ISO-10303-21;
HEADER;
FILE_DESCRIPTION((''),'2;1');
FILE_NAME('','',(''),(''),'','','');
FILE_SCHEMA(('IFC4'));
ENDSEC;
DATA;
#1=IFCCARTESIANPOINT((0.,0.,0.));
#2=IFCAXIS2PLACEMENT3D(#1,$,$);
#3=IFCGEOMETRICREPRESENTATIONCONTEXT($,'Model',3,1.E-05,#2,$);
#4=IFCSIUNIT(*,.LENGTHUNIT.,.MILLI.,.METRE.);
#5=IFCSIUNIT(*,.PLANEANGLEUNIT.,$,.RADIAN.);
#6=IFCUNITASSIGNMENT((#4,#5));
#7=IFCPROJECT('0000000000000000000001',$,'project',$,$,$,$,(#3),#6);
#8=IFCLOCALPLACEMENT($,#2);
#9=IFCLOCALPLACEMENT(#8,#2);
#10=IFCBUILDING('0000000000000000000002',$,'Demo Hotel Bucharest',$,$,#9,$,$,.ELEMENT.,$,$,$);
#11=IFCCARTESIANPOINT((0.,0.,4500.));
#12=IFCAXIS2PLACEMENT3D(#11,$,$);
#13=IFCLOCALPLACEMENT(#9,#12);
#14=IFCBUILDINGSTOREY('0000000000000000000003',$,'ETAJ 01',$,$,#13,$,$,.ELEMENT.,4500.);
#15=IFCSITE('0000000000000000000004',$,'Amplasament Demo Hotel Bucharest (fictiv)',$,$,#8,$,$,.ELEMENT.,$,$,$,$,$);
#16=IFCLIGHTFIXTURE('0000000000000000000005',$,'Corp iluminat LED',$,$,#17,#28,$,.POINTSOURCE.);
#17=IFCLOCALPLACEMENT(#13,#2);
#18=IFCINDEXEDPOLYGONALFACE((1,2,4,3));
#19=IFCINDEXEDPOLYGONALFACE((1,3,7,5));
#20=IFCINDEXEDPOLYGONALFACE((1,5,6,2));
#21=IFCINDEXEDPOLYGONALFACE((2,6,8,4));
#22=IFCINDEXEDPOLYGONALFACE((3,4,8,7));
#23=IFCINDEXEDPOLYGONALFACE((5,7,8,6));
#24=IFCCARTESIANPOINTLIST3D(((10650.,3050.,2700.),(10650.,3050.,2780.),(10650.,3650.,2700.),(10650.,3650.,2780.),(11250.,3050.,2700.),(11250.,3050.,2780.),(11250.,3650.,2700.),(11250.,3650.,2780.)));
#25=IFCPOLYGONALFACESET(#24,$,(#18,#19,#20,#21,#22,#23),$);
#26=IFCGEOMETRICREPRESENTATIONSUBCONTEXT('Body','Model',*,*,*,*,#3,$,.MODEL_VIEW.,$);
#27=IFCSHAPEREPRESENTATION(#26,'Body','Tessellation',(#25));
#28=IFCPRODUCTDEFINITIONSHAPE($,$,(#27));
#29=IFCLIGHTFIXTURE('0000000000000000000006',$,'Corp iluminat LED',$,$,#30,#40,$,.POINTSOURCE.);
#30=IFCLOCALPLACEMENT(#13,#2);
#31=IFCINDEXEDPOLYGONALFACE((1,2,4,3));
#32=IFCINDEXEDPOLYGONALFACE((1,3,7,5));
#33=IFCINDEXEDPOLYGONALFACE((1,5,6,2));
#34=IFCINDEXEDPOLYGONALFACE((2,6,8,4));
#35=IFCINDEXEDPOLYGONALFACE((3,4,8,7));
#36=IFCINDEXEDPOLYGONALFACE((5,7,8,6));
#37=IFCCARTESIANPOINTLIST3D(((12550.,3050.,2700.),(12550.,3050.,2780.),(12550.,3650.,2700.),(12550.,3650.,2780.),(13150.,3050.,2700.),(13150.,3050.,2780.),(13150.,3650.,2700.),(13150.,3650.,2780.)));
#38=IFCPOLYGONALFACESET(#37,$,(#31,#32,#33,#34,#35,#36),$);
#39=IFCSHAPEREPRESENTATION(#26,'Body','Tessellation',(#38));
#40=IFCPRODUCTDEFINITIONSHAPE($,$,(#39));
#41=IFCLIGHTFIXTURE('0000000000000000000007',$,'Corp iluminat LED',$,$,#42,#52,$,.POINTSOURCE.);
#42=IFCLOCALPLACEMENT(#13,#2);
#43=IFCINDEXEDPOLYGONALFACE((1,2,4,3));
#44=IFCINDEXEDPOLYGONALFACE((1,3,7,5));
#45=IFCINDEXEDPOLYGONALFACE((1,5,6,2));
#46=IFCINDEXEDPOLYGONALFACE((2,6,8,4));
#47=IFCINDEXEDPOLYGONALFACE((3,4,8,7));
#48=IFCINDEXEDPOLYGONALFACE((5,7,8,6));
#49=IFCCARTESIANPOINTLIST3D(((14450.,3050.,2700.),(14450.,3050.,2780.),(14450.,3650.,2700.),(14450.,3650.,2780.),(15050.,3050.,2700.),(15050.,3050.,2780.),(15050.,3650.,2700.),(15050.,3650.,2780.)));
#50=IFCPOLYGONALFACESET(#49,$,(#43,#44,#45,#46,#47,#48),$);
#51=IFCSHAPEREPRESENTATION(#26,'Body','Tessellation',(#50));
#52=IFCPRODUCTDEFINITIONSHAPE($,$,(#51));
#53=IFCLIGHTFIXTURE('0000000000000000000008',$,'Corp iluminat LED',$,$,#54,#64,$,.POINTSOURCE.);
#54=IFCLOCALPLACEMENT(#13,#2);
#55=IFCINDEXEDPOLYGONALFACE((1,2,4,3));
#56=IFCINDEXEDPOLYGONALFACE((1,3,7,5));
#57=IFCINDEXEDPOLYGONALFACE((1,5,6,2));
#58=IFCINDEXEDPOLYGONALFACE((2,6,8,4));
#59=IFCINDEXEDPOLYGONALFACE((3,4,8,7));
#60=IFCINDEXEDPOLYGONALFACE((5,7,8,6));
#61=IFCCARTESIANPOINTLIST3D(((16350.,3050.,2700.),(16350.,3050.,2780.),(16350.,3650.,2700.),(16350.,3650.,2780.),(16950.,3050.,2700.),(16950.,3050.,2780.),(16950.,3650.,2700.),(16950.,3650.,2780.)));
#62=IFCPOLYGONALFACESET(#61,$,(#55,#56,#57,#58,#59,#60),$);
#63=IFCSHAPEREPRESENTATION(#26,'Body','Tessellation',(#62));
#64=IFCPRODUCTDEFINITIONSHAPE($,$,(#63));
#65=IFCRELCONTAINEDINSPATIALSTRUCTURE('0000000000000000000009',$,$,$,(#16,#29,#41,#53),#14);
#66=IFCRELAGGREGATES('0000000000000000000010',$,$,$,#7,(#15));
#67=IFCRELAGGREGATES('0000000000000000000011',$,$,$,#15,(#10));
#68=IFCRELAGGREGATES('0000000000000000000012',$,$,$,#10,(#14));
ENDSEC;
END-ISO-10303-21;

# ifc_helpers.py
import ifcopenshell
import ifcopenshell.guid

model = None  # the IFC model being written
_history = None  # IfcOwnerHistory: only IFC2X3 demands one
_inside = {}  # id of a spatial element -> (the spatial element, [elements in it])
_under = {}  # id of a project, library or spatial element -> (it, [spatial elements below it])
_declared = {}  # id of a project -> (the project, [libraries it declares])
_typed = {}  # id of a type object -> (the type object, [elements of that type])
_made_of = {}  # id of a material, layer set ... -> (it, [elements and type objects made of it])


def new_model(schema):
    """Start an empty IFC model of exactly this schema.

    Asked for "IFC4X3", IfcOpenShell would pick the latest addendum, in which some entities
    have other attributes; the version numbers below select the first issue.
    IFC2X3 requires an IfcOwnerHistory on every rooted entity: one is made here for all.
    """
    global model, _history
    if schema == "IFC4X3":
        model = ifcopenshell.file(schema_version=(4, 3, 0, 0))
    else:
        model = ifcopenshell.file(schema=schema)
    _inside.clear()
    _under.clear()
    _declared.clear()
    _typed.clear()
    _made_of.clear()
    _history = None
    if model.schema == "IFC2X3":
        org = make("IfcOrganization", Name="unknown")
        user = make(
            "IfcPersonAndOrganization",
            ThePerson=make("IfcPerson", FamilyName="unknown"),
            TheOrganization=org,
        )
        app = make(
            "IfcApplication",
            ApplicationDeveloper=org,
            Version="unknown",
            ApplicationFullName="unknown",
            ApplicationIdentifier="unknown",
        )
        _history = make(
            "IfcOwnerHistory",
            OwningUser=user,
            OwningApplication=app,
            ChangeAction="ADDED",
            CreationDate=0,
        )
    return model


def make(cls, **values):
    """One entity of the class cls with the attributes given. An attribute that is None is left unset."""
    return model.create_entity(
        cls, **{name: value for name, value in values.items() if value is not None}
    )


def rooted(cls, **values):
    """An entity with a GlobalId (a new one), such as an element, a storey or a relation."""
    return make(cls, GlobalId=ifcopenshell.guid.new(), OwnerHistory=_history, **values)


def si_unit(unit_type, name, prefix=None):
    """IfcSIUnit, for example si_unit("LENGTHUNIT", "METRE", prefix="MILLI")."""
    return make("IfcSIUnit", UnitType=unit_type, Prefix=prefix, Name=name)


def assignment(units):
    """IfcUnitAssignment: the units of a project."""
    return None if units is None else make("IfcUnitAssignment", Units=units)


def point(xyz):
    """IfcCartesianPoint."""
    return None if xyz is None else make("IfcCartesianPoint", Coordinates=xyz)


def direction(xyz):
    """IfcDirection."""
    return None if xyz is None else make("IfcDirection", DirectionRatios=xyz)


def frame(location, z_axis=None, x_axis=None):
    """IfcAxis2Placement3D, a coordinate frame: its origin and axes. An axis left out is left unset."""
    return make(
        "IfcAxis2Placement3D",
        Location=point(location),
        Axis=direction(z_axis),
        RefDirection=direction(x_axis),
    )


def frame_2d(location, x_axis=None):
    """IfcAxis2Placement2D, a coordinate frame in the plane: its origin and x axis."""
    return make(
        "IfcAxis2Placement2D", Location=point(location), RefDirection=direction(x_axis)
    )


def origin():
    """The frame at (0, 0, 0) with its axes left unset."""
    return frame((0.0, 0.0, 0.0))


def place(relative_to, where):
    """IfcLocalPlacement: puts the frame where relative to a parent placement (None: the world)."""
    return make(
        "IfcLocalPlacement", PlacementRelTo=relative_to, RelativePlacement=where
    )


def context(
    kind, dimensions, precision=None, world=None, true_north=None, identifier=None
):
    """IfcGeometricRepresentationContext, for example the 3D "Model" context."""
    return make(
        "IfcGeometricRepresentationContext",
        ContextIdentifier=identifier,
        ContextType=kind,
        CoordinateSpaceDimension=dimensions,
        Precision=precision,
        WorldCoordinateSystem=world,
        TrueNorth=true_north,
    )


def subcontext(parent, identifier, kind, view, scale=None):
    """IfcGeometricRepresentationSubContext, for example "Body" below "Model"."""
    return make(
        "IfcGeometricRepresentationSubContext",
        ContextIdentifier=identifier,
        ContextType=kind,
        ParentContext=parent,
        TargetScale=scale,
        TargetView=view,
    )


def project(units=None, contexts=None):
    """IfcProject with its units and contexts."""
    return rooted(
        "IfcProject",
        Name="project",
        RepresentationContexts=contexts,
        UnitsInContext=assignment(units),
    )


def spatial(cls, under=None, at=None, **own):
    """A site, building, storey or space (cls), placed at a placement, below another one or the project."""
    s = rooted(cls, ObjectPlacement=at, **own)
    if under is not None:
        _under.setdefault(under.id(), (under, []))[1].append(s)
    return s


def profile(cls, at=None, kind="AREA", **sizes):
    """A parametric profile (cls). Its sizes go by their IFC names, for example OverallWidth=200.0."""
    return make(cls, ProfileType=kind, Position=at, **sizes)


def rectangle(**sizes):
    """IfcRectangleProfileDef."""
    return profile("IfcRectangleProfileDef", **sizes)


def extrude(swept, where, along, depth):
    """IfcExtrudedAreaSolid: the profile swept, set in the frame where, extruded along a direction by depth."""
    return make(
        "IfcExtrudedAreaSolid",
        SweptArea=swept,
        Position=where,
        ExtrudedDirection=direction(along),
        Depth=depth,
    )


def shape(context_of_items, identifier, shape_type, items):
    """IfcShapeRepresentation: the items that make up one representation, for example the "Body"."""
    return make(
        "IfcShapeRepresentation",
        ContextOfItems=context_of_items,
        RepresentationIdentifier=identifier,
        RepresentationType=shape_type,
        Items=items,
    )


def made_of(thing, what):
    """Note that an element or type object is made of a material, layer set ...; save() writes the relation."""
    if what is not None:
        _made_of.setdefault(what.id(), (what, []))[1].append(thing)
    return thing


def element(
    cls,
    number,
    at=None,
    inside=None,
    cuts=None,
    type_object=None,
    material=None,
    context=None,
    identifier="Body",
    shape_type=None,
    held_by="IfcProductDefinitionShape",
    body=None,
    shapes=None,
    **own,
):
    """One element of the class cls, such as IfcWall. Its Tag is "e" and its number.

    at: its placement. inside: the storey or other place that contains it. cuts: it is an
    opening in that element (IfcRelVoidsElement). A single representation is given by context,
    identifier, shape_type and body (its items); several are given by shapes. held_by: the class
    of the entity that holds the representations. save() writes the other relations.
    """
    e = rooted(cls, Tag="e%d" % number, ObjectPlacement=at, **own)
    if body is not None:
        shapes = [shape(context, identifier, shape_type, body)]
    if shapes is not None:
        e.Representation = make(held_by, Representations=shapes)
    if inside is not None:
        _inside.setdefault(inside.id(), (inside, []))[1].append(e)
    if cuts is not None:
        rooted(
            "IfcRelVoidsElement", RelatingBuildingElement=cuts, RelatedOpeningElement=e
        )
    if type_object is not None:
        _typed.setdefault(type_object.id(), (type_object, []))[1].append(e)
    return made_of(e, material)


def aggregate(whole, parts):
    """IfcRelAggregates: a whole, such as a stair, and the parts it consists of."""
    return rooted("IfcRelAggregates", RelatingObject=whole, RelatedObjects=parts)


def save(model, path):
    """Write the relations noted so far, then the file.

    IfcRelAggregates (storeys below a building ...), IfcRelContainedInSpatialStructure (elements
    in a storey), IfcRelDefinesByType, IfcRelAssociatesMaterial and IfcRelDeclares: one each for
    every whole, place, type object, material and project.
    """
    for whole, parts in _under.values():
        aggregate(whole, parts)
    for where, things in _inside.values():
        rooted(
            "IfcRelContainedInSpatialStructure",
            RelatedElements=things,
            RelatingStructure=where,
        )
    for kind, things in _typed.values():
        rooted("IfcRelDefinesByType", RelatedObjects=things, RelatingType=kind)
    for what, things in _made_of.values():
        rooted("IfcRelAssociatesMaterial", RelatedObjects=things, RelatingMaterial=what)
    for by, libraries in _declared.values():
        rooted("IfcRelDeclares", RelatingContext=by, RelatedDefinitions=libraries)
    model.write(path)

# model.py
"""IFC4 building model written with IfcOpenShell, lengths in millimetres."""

from ifc_helpers import new_model, si_unit, frame, frame_2d, origin, place, context, subcontext, project, spatial, rectangle, extrude, element, save


model = new_model("IFC4")

# Units and contexts
model_context = context("Model", 3, precision=1e-05, world=origin())
body_context = subcontext(model_context, "Body", "Model", "MODEL_VIEW")
ifc_project = project(units=[si_unit("LENGTHUNIT", "METRE", prefix="MILLI"), si_unit("PLANEANGLEUNIT", "RADIAN")], contexts=[model_context])

# Site, building, storey
site_placement = place(None, origin())
site = spatial("IfcSite", under=ifc_project, at=site_placement, Name="Amplasament Demo Hotel Bucharest (fictiv)", CompositionType="ELEMENT")
building_placement = place(site_placement, origin())
building = spatial("IfcBuilding", under=site, at=building_placement, Name="Demo Hotel Bucharest", CompositionType="ELEMENT")
storey_placement = place(building_placement, frame((0.0, 0.0, 4500.0)))
storey = spatial("IfcBuildingStorey", under=building, at=storey_placement, Name="ETAJ 01", CompositionType="ELEMENT", Elevation=4500.0)

# Light fixtures
for number, where, name in (
    (1, (10650.0, 3050.0, 2700.0), "Corp iluminat LED"),
    (2, (12550.0, 3050.0, 2700.0), "Corp iluminat LED"),
    (3, (14450.0, 3050.0, 2700.0), "Corp iluminat LED"),
    (4, (16350.0, 3050.0, 2700.0), "Corp iluminat LED"),
):
    element("IfcLightFixture", number, at=place(storey_placement, frame(where)), inside=storey, Name=name, PredefinedType="POINTSOURCE", context=body_context, shape_type="SweptSolid", body=[
        extrude(rectangle(XDim=600.0, YDim=600.0, at=frame_2d((300.0, 300.0))), origin(), (0.0, 0.0, 1.0), 80.0),
    ])

save(model, "model.ifc")
